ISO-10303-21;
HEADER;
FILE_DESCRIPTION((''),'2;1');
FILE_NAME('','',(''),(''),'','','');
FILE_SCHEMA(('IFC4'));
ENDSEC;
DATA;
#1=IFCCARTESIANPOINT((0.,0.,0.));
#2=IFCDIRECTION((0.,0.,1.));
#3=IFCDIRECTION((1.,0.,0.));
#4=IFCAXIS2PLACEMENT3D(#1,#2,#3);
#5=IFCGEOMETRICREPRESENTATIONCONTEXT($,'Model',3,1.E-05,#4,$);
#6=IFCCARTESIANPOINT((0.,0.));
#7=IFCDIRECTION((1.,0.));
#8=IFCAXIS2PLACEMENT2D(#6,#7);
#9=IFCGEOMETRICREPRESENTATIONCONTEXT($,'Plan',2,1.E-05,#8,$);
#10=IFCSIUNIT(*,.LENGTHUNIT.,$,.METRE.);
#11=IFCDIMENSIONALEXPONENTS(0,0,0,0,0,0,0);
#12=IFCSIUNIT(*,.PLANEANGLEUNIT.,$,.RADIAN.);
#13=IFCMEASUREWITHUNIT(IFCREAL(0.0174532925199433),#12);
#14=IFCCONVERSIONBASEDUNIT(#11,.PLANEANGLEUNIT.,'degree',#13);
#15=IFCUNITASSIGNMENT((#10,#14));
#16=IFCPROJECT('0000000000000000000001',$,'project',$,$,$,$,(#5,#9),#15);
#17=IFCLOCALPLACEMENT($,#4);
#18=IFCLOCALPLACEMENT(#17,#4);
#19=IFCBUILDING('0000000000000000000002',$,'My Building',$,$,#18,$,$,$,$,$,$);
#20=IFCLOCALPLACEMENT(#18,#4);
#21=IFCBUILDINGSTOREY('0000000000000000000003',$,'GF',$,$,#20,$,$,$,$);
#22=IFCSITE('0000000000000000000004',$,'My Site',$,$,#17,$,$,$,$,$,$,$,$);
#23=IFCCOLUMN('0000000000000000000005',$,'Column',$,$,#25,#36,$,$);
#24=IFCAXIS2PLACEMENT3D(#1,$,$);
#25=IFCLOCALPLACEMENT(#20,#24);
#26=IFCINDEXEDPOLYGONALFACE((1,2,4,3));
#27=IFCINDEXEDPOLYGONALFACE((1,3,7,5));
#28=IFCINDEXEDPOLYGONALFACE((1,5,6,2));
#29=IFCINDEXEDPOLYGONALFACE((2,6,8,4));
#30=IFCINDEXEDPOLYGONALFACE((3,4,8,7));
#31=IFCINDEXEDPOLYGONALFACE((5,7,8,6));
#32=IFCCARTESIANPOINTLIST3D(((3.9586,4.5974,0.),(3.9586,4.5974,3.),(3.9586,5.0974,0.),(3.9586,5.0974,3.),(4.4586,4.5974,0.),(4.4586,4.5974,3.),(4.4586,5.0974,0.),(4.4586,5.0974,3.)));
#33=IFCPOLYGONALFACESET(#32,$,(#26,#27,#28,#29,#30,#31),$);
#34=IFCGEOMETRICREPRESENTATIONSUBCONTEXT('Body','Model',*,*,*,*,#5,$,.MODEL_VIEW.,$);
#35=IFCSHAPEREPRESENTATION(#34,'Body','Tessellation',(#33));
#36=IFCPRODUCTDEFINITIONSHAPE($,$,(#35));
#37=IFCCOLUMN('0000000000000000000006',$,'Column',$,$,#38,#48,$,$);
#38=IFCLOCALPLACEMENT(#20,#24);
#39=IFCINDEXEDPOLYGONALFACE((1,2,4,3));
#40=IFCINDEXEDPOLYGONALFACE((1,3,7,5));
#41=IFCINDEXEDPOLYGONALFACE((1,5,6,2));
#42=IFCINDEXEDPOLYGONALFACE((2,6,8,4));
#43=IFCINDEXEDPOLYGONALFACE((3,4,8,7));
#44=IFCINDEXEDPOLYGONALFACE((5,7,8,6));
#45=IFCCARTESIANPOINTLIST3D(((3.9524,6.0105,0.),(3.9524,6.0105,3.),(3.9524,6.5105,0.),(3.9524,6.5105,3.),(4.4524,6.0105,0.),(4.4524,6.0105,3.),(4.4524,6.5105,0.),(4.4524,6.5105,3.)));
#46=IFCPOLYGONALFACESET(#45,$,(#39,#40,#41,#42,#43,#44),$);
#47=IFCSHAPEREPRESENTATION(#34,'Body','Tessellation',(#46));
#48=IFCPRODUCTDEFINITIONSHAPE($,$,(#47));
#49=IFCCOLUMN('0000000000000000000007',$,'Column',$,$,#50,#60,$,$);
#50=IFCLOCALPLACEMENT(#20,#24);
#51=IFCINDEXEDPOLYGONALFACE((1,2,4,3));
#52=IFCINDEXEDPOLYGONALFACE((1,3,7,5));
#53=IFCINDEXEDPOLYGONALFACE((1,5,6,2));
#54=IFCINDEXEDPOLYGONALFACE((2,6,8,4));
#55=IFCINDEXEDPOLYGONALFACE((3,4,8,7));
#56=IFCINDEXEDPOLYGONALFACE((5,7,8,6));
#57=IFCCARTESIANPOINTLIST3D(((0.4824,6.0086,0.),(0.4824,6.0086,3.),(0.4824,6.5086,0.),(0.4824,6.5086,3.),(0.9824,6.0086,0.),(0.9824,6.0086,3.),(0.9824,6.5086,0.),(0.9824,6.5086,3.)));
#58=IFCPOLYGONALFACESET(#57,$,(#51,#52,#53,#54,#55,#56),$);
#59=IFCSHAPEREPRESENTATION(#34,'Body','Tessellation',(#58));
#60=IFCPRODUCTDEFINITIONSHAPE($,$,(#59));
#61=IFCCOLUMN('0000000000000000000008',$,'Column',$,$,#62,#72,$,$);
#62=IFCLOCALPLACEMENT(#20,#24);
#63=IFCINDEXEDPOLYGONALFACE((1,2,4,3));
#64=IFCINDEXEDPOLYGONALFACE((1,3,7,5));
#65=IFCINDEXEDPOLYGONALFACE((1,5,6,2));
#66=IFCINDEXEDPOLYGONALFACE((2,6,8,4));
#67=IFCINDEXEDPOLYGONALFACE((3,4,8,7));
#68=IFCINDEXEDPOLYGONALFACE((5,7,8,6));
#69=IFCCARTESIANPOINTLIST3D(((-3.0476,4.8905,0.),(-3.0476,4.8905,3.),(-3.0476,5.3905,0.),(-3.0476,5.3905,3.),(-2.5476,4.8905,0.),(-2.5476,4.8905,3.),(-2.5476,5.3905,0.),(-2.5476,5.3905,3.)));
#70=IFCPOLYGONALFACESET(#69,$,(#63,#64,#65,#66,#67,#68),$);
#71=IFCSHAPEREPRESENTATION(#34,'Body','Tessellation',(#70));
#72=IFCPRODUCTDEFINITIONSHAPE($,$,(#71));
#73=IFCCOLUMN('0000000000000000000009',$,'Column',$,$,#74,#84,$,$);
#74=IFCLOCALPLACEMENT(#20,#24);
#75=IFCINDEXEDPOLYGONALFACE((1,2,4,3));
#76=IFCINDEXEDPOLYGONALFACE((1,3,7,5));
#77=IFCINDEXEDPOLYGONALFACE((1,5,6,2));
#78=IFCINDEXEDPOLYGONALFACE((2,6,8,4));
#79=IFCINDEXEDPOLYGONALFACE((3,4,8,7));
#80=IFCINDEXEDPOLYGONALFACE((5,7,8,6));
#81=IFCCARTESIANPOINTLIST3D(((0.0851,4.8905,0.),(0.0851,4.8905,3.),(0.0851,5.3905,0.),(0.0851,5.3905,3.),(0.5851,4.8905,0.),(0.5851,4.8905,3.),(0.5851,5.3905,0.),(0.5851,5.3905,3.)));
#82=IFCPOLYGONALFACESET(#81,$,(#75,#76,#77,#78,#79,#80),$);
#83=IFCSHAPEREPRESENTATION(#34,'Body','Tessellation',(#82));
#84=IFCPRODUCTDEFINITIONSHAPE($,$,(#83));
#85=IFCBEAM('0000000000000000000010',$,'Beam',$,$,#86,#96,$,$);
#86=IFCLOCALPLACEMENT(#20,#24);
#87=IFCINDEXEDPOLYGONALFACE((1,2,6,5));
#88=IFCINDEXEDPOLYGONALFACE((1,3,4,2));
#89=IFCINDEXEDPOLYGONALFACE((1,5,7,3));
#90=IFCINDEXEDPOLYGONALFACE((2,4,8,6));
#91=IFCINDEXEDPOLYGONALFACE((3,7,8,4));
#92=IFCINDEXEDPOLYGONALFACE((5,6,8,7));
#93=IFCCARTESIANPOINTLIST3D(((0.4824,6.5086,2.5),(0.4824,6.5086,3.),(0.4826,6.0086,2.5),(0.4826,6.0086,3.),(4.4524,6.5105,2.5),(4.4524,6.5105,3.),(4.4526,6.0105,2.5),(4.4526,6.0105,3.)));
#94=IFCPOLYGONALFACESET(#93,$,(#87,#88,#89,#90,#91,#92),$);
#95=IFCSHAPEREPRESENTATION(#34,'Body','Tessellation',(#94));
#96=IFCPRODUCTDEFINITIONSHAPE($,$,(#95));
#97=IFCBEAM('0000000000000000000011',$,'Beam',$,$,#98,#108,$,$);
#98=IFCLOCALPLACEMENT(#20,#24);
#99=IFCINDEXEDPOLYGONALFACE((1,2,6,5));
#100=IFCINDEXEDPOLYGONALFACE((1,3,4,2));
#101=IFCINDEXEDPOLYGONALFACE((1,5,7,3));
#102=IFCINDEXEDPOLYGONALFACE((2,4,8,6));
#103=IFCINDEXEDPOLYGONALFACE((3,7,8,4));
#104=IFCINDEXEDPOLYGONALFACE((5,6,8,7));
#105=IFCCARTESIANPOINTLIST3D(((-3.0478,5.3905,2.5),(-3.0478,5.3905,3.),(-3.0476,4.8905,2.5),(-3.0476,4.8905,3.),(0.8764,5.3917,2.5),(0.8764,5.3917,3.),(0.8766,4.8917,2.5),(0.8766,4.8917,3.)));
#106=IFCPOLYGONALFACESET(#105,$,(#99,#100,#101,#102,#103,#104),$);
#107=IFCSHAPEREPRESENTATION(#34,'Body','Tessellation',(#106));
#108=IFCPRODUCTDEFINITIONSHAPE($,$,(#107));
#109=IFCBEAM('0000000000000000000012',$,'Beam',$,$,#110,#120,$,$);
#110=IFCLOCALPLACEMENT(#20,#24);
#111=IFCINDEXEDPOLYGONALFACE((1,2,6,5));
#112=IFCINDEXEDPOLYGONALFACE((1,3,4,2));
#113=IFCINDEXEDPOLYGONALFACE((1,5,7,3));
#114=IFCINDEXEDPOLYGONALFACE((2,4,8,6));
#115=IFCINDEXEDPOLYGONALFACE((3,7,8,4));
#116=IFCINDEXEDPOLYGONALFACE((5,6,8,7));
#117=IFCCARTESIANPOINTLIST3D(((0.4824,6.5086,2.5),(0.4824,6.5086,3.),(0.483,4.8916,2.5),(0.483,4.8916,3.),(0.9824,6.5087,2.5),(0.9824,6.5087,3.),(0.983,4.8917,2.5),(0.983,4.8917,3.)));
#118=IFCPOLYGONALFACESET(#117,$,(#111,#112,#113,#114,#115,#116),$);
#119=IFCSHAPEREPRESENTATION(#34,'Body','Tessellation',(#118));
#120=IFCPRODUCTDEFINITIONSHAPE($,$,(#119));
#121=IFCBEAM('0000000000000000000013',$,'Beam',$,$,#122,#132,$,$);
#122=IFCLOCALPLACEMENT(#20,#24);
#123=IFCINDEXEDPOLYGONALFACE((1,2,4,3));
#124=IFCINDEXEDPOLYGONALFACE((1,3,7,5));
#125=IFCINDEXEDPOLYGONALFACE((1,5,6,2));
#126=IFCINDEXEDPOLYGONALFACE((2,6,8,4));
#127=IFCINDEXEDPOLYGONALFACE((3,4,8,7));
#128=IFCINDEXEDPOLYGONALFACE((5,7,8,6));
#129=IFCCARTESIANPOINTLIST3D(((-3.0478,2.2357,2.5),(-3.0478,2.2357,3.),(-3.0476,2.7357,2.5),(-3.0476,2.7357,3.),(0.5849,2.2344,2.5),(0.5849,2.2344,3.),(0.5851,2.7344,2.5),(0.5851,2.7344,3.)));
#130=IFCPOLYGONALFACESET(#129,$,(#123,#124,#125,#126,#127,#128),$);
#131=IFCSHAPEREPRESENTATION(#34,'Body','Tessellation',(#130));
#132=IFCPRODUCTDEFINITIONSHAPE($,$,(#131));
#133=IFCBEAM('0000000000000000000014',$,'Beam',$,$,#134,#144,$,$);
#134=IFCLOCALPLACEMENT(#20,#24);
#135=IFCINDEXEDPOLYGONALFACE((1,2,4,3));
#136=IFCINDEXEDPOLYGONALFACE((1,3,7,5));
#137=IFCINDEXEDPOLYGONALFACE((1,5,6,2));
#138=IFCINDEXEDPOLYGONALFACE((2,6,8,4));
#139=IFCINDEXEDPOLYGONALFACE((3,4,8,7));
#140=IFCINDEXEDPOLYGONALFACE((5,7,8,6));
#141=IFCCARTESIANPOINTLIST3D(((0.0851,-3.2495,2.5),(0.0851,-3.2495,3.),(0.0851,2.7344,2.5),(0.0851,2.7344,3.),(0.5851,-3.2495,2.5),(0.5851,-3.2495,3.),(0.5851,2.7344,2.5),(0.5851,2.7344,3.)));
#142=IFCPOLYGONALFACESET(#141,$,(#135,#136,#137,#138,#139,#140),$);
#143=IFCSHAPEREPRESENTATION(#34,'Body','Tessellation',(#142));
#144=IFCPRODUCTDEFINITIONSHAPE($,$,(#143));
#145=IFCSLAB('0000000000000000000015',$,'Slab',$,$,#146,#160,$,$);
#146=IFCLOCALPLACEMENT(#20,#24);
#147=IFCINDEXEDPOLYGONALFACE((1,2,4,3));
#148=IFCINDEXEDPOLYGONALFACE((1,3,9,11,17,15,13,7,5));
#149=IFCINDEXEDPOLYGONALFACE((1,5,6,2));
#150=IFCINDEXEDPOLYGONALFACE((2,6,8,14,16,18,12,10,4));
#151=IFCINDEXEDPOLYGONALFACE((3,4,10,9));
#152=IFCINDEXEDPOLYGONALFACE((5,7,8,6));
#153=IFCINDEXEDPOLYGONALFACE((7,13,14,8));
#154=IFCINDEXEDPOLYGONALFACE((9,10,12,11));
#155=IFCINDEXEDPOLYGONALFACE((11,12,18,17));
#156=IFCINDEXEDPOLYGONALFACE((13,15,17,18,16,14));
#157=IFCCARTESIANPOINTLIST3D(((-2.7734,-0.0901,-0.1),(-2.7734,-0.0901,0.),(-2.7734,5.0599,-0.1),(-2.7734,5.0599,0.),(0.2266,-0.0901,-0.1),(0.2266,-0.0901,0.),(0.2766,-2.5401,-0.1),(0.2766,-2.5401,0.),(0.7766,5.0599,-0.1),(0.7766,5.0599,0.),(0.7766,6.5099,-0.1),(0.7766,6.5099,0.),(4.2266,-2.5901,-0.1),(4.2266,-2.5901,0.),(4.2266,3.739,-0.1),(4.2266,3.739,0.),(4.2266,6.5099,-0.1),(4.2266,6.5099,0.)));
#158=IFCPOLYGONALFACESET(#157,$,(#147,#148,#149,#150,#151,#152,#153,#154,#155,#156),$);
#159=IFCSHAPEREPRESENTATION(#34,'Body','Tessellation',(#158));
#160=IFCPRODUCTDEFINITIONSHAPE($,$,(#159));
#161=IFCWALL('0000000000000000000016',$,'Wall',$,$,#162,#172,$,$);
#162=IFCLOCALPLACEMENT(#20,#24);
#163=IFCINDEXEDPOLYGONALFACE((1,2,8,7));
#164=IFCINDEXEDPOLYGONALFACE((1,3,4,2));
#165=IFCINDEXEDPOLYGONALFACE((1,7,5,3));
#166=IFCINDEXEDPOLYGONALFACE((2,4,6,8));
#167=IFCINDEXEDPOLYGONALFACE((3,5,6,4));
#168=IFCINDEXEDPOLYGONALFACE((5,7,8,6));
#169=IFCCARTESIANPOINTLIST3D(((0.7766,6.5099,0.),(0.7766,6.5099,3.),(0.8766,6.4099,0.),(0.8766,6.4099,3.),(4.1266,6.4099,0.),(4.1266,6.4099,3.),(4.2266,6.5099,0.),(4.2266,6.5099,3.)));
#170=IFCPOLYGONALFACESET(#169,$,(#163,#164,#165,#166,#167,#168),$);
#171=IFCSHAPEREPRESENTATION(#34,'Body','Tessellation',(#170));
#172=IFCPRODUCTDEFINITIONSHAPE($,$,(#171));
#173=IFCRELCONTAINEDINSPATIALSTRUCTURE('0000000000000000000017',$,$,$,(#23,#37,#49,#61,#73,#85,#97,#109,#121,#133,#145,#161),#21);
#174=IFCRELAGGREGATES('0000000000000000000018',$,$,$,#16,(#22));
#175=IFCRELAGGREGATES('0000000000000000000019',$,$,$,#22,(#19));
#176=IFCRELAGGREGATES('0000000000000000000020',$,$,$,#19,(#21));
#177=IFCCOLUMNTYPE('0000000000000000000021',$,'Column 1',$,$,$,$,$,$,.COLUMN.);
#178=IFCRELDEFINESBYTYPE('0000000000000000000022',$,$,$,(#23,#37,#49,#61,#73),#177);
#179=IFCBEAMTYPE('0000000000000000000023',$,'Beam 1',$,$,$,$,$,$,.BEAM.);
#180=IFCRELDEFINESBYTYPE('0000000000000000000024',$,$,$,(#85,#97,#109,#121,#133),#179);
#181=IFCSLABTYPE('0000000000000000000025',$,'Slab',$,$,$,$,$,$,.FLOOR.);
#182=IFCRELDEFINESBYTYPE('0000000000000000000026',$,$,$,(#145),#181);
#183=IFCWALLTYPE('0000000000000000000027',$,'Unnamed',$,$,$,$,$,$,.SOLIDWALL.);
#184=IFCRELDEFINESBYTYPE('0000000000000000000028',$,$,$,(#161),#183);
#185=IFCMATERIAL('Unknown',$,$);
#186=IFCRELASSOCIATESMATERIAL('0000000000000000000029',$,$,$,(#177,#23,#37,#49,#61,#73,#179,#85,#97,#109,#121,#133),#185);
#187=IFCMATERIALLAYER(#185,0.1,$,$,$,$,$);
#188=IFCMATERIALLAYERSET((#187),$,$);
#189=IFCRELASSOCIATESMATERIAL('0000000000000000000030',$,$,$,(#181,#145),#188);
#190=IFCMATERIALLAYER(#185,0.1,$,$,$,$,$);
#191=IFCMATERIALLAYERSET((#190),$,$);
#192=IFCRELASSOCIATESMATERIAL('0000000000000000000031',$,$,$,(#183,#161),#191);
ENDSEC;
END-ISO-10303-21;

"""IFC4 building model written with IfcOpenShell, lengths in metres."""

from ifc_helpers import new_model, entity, si_unit, converted_unit, frame, origin_with_axes, origin_2d_with_axis, place, context, subcontext, project, spatial, line, indexed_curve, outline, extrude, material, layer, layer_set, layer_usage, material_profile, profile_set, profile_usage, type_object, element, save


model = new_model("IFC4")

# Units and contexts
model_context = context("Model", 3, precision=1e-05, world=origin_with_axes())
plan_context = context("Plan", 2, precision=1e-05, world=origin_2d_with_axis())
body_context_1 = subcontext(model_context, "Body", "Model", "MODEL_VIEW")
ifc_project = project(units=[si_unit("LENGTHUNIT", "METRE"), converted_unit("PLANEANGLEUNIT", "degree", entity("IfcReal", 0.0174532925199433), si_unit("PLANEANGLEUNIT", "RADIAN"), dimensions=[0, 0, 0, 0, 0, 0, 0])], contexts=[model_context, plan_context])

# Site, building, storey
site_placement = place(None, origin_with_axes())
site = spatial("IfcSite", under=ifc_project, at=site_placement, Name="My Site")
building_placement = place(site_placement, origin_with_axes())
building = spatial("IfcBuilding", under=site, at=building_placement, Name="My Building")
storey_placement = place(building_placement, origin_with_axes())
storey = spatial("IfcBuildingStorey", under=building, at=storey_placement, Name="GF")

# Columns
ifc_material_1 = material(Name="Unknown")
ifc_material_profile_1 = material_profile(ifc_material_1, outline(indexed_curve([(-0.25, -0.25), (0.25, -0.25), (0.25, 0.25), (-0.25, 0.25), (-0.25, -0.25)])))
ifc_profile_set_1 = profile_set([ifc_material_profile_1])
ifc_profile_usage_1 = profile_usage(ifc_profile_set_1, cardinal=3)
column_type = type_object("IfcColumnType", Name="Column 1", PredefinedType="COLUMN", material=ifc_profile_set_1)
column_1_placement = place(storey_placement, frame((3.9586, 4.5974, 0.0), z_axis=(0.0, 0.0, 1.0), x_axis=(1.0, 0.0, 0.0)))
element("IfcColumn", 1, at=column_1_placement, inside=storey, type_object=column_type, material=ifc_profile_usage_1, Name="Column", context=body_context_1, shape_type="SweptSolid", body=[
    extrude(outline(indexed_curve([(-0.25, -0.25), (0.25, -0.25), (0.25, 0.25), (-0.25, 0.25), (-0.25, -0.25)])), frame((0.25, 0.25, 0.0), z_axis=(0.0, 0.0, 1.0), x_axis=(1.0, 0.0, 0.0)), (0.0, 0.0, 1.0), 3.0),
])
ifc_profile_usage_2 = profile_usage(ifc_profile_set_1, cardinal=7)
column_2_placement = place(storey_placement, frame((4.4524, 6.5105, 0.0), z_axis=(0.0, 0.0, 1.0), x_axis=(1.0, 0.0, 0.0)))
element("IfcColumn", 2, at=column_2_placement, inside=storey, type_object=column_type, material=ifc_profile_usage_2, Name="Column", context=body_context_1, shape_type="SweptSolid", body=[
    extrude(outline(indexed_curve([(-0.25, -0.25), (0.25, -0.25), (0.25, 0.25), (-0.25, 0.25), (-0.25, -0.25)])), frame((-0.25, -0.25, 0.0), z_axis=(0.0, 0.0, 1.0), x_axis=(1.0, 0.0, 0.0)), (0.0, 0.0, 1.0), 3.0),
])
ifc_profile_usage_3 = profile_usage(ifc_profile_set_1, cardinal=9)
column_3_placement = place(storey_placement, frame((0.4824, 6.5086, 0.0), z_axis=(0.0, 0.0, 1.0), x_axis=(1.0, 0.0, 0.0)))
element("IfcColumn", 3, at=column_3_placement, inside=storey, type_object=column_type, material=ifc_profile_usage_3, Name="Column", context=body_context_1, shape_type="SweptSolid", body=[
    extrude(outline(indexed_curve([(-0.25, -0.25), (0.25, -0.25), (0.25, 0.25), (-0.25, 0.25), (-0.25, -0.25)])), frame((0.25, -0.25, 0.0), z_axis=(0.0, 0.0, 1.0), x_axis=(1.0, 0.0, 0.0)), (0.0, 0.0, 1.0), 3.0),
])
ifc_profile_usage_4 = profile_usage(ifc_profile_set_1, cardinal=3)
column_4_placement = place(storey_placement, frame((-3.0476, 4.8905, 0.0), z_axis=(0.0, 0.0, 1.0), x_axis=(1.0, 0.0, 0.0)))
element("IfcColumn", 4, at=column_4_placement, inside=storey, type_object=column_type, material=ifc_profile_usage_4, Name="Column", context=body_context_1, shape_type="SweptSolid", body=[
    extrude(outline(indexed_curve([(-0.25, -0.25), (0.25, -0.25), (0.25, 0.25), (-0.25, 0.25), (-0.25, -0.25)])), frame((0.25, 0.25, 0.0), z_axis=(0.0, 0.0, 1.0), x_axis=(1.0, 0.0, 0.0)), (0.0, 0.0, 1.0), 3.0),
])
ifc_profile_usage_5 = profile_usage(ifc_profile_set_1, cardinal=3)
column_5_placement = place(storey_placement, frame((0.0851, 4.8905, 0.0), z_axis=(0.0, 0.0, 1.0), x_axis=(1.0, 0.0, 0.0)))
element("IfcColumn", 5, at=column_5_placement, inside=storey, type_object=column_type, material=ifc_profile_usage_5, Name="Column", context=body_context_1, shape_type="SweptSolid", body=[
    extrude(outline(indexed_curve([(-0.25, -0.25), (0.25, -0.25), (0.25, 0.25), (-0.25, 0.25), (-0.25, -0.25)])), frame((0.25, 0.25, 0.0), z_axis=(0.0, 0.0, 1.0), x_axis=(1.0, 0.0, 0.0)), (0.0, 0.0, 1.0), 3.0),
])

# Beams
ifc_material_profile_2 = material_profile(ifc_material_1, outline(indexed_curve([(-0.25, -0.25), (0.25, -0.25), (0.25, 0.25), (-0.25, 0.25), (-0.25, -0.25)])))
ifc_profile_set_2 = profile_set([ifc_material_profile_2])
ifc_profile_usage_6 = profile_usage(ifc_profile_set_2, cardinal=9)
beam_type = type_object("IfcBeamType", Name="Beam 1", PredefinedType="BEAM", material=ifc_profile_set_2)
beam_1_placement = place(storey_placement, frame((4.4524, 6.5105, 3.0), z_axis=(-1.0, -0.00048, 0.0), x_axis=(0.00048, -1.0, 0.0)))
element("IfcBeam", 6, at=beam_1_placement, inside=storey, type_object=beam_type, material=ifc_profile_usage_6, Name="Beam", context=body_context_1, shape_type="SweptSolid", body=[
    extrude(outline(indexed_curve([(-0.25, -0.25), (0.25, -0.25), (0.25, 0.25), (-0.25, 0.25), (-0.25, -0.25)])), frame((0.25, -0.25, 0.0), z_axis=(0.0, 0.0, 1.0), x_axis=(1.0, 0.0, 0.0)), (0.0, 0.0, 1.0), 3.97),
])
ifc_profile_usage_7 = profile_usage(ifc_profile_set_2, cardinal=9)
beam_2_placement = place(storey_placement, frame((-3.0476, 4.8905, 3.0), z_axis=(1.0, 0.000311, 0.0), x_axis=(-0.000311, 1.0, 0.0)))
element("IfcBeam", 7, at=beam_2_placement, inside=storey, type_object=beam_type, material=ifc_profile_usage_7, Name="Beam", context=body_context_1, shape_type="SweptSolid", body=[
    extrude(outline(indexed_curve([(-0.25, -0.25), (0.25, -0.25), (0.25, 0.25), (-0.25, 0.25), (-0.25, -0.25)])), frame((0.25, -0.25, 0.0), z_axis=(0.0, 0.0, 1.0), x_axis=(1.0, 0.0, 0.0)), (0.0, 0.0, 1.0), 3.9242),
])
ifc_profile_usage_8 = profile_usage(ifc_profile_set_2, cardinal=9)
beam_3_placement = place(storey_placement, frame((0.4824, 6.5086, 3.0), z_axis=(0.000354, -1.0, -0.000001), x_axis=(1.0, 0.000354, 0.0)))
element("IfcBeam", 8, at=beam_3_placement, inside=storey, type_object=beam_type, material=ifc_profile_usage_8, Name="Beam", context=body_context_1, shape_type="SweptSolid", body=[
    extrude(outline(indexed_curve([(-0.25, -0.25), (0.25, -0.25), (0.25, 0.25), (-0.25, 0.25), (-0.25, -0.25)])), frame((0.25, -0.25, 0.0), z_axis=(0.0, 0.0, 1.0), x_axis=(1.0, 0.0, 0.0)), (0.0, 0.0, 1.0), 1.617),
])
ifc_profile_usage_9 = profile_usage(ifc_profile_set_2, cardinal=7)
beam_4_placement = place(storey_placement, frame((-3.0476, 2.7357, 3.0), z_axis=(1.0, -0.000353, 0.0), x_axis=(0.000353, 1.0, 0.0)))
element("IfcBeam", 9, at=beam_4_placement, inside=storey, type_object=beam_type, material=ifc_profile_usage_9, Name="Beam", context=body_context_1, shape_type="SweptSolid", body=[
    extrude(outline(indexed_curve([(-0.25, -0.25), (0.25, -0.25), (0.25, 0.25), (-0.25, 0.25), (-0.25, -0.25)])), frame((-0.25, -0.25, 0.0), z_axis=(0.0, 0.0, 1.0), x_axis=(1.0, 0.0, 0.0)), (0.0, 0.0, 1.0), 3.6327),
])
ifc_profile_usage_10 = profile_usage(ifc_profile_set_2, cardinal=7)
beam_5_placement = place(storey_placement, frame((0.5851, 2.7344, 3.0), z_axis=(0.0, -1.0, 0.0), x_axis=(1.0, 0.0, 0.0)))
element("IfcBeam", 10, at=beam_5_placement, inside=storey, type_object=beam_type, material=ifc_profile_usage_10, Name="Beam", context=body_context_1, shape_type="SweptSolid", body=[
    extrude(outline(indexed_curve([(-0.25, -0.25), (0.25, -0.25), (0.25, 0.25), (-0.25, 0.25), (-0.25, -0.25)])), frame((-0.25, -0.25, 0.0), z_axis=(0.0, 0.0, 1.0), x_axis=(1.0, 0.0, 0.0)), (0.0, 0.0, 1.0), 5.9839),
])

# Slab
ifc_layer_1 = layer(ifc_material_1, 0.1)
ifc_layer_set_1 = layer_set([ifc_layer_1])
ifc_layer_usage_1 = layer_usage(ifc_layer_set_1, "AXIS3", "POSITIVE", -0.1)
slab_type = type_object("IfcSlabType", Name="Slab", PredefinedType="FLOOR", material=ifc_layer_set_1)
slab_placement = place(storey_placement, frame((4.2266, 6.5099, 0.0), z_axis=(0.0, 0.0, 1.0), x_axis=(1.0, 0.0, 0.0)))
element("IfcSlab", 11, at=slab_placement, inside=storey, type_object=slab_type, material=ifc_layer_usage_1, Name="Slab", context=body_context_1, shape_type="SweptSolid", body=[
    extrude(outline(indexed_curve([(0.0, 0.0), (-3.45, 0.0), (-3.45, -1.45), (-7.0, -1.45), (-7.0, -6.6), (-4.0, -6.6), (-3.95, -9.05), (0.0, -9.1), (0.0, -2.7709), (0.0, 0.0)])), frame((0.0, 0.0, -0.1), z_axis=(0.0, 0.0, 1.0), x_axis=(1.0, 0.0, 0.0)), (0.0, 0.0, 1.0), 0.1),
])

# Wall
ifc_layer_2 = layer(ifc_material_1, 0.1)
ifc_layer_set_2 = layer_set([ifc_layer_2])
ifc_layer_usage_2 = layer_usage(ifc_layer_set_2, "AXIS2", "POSITIVE", 0.0)
wall_type = type_object("IfcWallType", Name="Unnamed", PredefinedType="SOLIDWALL", material=ifc_layer_set_2)
wall_1_placement = place(storey_placement, frame((4.2266, 6.5099, 0.0), z_axis=(0.0, 0.0, 1.0), x_axis=(-1.0, 0.0, 0.0)))
element("IfcWall", 12, at=wall_1_placement, inside=storey, type_object=wall_type, material=ifc_layer_usage_2, Name="Wall", context=body_context_1, shape_type="SweptSolid", body=[
    extrude(outline(indexed_curve([(0.0, 0.0), (0.1, 0.1), (3.35, 0.1), (3.45, 0.0)], segments=[line(1, 2, 3, 4, 1)])), origin_with_axes(), (0.0, 0.0, 1.0), 3.0),
])

save(model, "model.ifc")
